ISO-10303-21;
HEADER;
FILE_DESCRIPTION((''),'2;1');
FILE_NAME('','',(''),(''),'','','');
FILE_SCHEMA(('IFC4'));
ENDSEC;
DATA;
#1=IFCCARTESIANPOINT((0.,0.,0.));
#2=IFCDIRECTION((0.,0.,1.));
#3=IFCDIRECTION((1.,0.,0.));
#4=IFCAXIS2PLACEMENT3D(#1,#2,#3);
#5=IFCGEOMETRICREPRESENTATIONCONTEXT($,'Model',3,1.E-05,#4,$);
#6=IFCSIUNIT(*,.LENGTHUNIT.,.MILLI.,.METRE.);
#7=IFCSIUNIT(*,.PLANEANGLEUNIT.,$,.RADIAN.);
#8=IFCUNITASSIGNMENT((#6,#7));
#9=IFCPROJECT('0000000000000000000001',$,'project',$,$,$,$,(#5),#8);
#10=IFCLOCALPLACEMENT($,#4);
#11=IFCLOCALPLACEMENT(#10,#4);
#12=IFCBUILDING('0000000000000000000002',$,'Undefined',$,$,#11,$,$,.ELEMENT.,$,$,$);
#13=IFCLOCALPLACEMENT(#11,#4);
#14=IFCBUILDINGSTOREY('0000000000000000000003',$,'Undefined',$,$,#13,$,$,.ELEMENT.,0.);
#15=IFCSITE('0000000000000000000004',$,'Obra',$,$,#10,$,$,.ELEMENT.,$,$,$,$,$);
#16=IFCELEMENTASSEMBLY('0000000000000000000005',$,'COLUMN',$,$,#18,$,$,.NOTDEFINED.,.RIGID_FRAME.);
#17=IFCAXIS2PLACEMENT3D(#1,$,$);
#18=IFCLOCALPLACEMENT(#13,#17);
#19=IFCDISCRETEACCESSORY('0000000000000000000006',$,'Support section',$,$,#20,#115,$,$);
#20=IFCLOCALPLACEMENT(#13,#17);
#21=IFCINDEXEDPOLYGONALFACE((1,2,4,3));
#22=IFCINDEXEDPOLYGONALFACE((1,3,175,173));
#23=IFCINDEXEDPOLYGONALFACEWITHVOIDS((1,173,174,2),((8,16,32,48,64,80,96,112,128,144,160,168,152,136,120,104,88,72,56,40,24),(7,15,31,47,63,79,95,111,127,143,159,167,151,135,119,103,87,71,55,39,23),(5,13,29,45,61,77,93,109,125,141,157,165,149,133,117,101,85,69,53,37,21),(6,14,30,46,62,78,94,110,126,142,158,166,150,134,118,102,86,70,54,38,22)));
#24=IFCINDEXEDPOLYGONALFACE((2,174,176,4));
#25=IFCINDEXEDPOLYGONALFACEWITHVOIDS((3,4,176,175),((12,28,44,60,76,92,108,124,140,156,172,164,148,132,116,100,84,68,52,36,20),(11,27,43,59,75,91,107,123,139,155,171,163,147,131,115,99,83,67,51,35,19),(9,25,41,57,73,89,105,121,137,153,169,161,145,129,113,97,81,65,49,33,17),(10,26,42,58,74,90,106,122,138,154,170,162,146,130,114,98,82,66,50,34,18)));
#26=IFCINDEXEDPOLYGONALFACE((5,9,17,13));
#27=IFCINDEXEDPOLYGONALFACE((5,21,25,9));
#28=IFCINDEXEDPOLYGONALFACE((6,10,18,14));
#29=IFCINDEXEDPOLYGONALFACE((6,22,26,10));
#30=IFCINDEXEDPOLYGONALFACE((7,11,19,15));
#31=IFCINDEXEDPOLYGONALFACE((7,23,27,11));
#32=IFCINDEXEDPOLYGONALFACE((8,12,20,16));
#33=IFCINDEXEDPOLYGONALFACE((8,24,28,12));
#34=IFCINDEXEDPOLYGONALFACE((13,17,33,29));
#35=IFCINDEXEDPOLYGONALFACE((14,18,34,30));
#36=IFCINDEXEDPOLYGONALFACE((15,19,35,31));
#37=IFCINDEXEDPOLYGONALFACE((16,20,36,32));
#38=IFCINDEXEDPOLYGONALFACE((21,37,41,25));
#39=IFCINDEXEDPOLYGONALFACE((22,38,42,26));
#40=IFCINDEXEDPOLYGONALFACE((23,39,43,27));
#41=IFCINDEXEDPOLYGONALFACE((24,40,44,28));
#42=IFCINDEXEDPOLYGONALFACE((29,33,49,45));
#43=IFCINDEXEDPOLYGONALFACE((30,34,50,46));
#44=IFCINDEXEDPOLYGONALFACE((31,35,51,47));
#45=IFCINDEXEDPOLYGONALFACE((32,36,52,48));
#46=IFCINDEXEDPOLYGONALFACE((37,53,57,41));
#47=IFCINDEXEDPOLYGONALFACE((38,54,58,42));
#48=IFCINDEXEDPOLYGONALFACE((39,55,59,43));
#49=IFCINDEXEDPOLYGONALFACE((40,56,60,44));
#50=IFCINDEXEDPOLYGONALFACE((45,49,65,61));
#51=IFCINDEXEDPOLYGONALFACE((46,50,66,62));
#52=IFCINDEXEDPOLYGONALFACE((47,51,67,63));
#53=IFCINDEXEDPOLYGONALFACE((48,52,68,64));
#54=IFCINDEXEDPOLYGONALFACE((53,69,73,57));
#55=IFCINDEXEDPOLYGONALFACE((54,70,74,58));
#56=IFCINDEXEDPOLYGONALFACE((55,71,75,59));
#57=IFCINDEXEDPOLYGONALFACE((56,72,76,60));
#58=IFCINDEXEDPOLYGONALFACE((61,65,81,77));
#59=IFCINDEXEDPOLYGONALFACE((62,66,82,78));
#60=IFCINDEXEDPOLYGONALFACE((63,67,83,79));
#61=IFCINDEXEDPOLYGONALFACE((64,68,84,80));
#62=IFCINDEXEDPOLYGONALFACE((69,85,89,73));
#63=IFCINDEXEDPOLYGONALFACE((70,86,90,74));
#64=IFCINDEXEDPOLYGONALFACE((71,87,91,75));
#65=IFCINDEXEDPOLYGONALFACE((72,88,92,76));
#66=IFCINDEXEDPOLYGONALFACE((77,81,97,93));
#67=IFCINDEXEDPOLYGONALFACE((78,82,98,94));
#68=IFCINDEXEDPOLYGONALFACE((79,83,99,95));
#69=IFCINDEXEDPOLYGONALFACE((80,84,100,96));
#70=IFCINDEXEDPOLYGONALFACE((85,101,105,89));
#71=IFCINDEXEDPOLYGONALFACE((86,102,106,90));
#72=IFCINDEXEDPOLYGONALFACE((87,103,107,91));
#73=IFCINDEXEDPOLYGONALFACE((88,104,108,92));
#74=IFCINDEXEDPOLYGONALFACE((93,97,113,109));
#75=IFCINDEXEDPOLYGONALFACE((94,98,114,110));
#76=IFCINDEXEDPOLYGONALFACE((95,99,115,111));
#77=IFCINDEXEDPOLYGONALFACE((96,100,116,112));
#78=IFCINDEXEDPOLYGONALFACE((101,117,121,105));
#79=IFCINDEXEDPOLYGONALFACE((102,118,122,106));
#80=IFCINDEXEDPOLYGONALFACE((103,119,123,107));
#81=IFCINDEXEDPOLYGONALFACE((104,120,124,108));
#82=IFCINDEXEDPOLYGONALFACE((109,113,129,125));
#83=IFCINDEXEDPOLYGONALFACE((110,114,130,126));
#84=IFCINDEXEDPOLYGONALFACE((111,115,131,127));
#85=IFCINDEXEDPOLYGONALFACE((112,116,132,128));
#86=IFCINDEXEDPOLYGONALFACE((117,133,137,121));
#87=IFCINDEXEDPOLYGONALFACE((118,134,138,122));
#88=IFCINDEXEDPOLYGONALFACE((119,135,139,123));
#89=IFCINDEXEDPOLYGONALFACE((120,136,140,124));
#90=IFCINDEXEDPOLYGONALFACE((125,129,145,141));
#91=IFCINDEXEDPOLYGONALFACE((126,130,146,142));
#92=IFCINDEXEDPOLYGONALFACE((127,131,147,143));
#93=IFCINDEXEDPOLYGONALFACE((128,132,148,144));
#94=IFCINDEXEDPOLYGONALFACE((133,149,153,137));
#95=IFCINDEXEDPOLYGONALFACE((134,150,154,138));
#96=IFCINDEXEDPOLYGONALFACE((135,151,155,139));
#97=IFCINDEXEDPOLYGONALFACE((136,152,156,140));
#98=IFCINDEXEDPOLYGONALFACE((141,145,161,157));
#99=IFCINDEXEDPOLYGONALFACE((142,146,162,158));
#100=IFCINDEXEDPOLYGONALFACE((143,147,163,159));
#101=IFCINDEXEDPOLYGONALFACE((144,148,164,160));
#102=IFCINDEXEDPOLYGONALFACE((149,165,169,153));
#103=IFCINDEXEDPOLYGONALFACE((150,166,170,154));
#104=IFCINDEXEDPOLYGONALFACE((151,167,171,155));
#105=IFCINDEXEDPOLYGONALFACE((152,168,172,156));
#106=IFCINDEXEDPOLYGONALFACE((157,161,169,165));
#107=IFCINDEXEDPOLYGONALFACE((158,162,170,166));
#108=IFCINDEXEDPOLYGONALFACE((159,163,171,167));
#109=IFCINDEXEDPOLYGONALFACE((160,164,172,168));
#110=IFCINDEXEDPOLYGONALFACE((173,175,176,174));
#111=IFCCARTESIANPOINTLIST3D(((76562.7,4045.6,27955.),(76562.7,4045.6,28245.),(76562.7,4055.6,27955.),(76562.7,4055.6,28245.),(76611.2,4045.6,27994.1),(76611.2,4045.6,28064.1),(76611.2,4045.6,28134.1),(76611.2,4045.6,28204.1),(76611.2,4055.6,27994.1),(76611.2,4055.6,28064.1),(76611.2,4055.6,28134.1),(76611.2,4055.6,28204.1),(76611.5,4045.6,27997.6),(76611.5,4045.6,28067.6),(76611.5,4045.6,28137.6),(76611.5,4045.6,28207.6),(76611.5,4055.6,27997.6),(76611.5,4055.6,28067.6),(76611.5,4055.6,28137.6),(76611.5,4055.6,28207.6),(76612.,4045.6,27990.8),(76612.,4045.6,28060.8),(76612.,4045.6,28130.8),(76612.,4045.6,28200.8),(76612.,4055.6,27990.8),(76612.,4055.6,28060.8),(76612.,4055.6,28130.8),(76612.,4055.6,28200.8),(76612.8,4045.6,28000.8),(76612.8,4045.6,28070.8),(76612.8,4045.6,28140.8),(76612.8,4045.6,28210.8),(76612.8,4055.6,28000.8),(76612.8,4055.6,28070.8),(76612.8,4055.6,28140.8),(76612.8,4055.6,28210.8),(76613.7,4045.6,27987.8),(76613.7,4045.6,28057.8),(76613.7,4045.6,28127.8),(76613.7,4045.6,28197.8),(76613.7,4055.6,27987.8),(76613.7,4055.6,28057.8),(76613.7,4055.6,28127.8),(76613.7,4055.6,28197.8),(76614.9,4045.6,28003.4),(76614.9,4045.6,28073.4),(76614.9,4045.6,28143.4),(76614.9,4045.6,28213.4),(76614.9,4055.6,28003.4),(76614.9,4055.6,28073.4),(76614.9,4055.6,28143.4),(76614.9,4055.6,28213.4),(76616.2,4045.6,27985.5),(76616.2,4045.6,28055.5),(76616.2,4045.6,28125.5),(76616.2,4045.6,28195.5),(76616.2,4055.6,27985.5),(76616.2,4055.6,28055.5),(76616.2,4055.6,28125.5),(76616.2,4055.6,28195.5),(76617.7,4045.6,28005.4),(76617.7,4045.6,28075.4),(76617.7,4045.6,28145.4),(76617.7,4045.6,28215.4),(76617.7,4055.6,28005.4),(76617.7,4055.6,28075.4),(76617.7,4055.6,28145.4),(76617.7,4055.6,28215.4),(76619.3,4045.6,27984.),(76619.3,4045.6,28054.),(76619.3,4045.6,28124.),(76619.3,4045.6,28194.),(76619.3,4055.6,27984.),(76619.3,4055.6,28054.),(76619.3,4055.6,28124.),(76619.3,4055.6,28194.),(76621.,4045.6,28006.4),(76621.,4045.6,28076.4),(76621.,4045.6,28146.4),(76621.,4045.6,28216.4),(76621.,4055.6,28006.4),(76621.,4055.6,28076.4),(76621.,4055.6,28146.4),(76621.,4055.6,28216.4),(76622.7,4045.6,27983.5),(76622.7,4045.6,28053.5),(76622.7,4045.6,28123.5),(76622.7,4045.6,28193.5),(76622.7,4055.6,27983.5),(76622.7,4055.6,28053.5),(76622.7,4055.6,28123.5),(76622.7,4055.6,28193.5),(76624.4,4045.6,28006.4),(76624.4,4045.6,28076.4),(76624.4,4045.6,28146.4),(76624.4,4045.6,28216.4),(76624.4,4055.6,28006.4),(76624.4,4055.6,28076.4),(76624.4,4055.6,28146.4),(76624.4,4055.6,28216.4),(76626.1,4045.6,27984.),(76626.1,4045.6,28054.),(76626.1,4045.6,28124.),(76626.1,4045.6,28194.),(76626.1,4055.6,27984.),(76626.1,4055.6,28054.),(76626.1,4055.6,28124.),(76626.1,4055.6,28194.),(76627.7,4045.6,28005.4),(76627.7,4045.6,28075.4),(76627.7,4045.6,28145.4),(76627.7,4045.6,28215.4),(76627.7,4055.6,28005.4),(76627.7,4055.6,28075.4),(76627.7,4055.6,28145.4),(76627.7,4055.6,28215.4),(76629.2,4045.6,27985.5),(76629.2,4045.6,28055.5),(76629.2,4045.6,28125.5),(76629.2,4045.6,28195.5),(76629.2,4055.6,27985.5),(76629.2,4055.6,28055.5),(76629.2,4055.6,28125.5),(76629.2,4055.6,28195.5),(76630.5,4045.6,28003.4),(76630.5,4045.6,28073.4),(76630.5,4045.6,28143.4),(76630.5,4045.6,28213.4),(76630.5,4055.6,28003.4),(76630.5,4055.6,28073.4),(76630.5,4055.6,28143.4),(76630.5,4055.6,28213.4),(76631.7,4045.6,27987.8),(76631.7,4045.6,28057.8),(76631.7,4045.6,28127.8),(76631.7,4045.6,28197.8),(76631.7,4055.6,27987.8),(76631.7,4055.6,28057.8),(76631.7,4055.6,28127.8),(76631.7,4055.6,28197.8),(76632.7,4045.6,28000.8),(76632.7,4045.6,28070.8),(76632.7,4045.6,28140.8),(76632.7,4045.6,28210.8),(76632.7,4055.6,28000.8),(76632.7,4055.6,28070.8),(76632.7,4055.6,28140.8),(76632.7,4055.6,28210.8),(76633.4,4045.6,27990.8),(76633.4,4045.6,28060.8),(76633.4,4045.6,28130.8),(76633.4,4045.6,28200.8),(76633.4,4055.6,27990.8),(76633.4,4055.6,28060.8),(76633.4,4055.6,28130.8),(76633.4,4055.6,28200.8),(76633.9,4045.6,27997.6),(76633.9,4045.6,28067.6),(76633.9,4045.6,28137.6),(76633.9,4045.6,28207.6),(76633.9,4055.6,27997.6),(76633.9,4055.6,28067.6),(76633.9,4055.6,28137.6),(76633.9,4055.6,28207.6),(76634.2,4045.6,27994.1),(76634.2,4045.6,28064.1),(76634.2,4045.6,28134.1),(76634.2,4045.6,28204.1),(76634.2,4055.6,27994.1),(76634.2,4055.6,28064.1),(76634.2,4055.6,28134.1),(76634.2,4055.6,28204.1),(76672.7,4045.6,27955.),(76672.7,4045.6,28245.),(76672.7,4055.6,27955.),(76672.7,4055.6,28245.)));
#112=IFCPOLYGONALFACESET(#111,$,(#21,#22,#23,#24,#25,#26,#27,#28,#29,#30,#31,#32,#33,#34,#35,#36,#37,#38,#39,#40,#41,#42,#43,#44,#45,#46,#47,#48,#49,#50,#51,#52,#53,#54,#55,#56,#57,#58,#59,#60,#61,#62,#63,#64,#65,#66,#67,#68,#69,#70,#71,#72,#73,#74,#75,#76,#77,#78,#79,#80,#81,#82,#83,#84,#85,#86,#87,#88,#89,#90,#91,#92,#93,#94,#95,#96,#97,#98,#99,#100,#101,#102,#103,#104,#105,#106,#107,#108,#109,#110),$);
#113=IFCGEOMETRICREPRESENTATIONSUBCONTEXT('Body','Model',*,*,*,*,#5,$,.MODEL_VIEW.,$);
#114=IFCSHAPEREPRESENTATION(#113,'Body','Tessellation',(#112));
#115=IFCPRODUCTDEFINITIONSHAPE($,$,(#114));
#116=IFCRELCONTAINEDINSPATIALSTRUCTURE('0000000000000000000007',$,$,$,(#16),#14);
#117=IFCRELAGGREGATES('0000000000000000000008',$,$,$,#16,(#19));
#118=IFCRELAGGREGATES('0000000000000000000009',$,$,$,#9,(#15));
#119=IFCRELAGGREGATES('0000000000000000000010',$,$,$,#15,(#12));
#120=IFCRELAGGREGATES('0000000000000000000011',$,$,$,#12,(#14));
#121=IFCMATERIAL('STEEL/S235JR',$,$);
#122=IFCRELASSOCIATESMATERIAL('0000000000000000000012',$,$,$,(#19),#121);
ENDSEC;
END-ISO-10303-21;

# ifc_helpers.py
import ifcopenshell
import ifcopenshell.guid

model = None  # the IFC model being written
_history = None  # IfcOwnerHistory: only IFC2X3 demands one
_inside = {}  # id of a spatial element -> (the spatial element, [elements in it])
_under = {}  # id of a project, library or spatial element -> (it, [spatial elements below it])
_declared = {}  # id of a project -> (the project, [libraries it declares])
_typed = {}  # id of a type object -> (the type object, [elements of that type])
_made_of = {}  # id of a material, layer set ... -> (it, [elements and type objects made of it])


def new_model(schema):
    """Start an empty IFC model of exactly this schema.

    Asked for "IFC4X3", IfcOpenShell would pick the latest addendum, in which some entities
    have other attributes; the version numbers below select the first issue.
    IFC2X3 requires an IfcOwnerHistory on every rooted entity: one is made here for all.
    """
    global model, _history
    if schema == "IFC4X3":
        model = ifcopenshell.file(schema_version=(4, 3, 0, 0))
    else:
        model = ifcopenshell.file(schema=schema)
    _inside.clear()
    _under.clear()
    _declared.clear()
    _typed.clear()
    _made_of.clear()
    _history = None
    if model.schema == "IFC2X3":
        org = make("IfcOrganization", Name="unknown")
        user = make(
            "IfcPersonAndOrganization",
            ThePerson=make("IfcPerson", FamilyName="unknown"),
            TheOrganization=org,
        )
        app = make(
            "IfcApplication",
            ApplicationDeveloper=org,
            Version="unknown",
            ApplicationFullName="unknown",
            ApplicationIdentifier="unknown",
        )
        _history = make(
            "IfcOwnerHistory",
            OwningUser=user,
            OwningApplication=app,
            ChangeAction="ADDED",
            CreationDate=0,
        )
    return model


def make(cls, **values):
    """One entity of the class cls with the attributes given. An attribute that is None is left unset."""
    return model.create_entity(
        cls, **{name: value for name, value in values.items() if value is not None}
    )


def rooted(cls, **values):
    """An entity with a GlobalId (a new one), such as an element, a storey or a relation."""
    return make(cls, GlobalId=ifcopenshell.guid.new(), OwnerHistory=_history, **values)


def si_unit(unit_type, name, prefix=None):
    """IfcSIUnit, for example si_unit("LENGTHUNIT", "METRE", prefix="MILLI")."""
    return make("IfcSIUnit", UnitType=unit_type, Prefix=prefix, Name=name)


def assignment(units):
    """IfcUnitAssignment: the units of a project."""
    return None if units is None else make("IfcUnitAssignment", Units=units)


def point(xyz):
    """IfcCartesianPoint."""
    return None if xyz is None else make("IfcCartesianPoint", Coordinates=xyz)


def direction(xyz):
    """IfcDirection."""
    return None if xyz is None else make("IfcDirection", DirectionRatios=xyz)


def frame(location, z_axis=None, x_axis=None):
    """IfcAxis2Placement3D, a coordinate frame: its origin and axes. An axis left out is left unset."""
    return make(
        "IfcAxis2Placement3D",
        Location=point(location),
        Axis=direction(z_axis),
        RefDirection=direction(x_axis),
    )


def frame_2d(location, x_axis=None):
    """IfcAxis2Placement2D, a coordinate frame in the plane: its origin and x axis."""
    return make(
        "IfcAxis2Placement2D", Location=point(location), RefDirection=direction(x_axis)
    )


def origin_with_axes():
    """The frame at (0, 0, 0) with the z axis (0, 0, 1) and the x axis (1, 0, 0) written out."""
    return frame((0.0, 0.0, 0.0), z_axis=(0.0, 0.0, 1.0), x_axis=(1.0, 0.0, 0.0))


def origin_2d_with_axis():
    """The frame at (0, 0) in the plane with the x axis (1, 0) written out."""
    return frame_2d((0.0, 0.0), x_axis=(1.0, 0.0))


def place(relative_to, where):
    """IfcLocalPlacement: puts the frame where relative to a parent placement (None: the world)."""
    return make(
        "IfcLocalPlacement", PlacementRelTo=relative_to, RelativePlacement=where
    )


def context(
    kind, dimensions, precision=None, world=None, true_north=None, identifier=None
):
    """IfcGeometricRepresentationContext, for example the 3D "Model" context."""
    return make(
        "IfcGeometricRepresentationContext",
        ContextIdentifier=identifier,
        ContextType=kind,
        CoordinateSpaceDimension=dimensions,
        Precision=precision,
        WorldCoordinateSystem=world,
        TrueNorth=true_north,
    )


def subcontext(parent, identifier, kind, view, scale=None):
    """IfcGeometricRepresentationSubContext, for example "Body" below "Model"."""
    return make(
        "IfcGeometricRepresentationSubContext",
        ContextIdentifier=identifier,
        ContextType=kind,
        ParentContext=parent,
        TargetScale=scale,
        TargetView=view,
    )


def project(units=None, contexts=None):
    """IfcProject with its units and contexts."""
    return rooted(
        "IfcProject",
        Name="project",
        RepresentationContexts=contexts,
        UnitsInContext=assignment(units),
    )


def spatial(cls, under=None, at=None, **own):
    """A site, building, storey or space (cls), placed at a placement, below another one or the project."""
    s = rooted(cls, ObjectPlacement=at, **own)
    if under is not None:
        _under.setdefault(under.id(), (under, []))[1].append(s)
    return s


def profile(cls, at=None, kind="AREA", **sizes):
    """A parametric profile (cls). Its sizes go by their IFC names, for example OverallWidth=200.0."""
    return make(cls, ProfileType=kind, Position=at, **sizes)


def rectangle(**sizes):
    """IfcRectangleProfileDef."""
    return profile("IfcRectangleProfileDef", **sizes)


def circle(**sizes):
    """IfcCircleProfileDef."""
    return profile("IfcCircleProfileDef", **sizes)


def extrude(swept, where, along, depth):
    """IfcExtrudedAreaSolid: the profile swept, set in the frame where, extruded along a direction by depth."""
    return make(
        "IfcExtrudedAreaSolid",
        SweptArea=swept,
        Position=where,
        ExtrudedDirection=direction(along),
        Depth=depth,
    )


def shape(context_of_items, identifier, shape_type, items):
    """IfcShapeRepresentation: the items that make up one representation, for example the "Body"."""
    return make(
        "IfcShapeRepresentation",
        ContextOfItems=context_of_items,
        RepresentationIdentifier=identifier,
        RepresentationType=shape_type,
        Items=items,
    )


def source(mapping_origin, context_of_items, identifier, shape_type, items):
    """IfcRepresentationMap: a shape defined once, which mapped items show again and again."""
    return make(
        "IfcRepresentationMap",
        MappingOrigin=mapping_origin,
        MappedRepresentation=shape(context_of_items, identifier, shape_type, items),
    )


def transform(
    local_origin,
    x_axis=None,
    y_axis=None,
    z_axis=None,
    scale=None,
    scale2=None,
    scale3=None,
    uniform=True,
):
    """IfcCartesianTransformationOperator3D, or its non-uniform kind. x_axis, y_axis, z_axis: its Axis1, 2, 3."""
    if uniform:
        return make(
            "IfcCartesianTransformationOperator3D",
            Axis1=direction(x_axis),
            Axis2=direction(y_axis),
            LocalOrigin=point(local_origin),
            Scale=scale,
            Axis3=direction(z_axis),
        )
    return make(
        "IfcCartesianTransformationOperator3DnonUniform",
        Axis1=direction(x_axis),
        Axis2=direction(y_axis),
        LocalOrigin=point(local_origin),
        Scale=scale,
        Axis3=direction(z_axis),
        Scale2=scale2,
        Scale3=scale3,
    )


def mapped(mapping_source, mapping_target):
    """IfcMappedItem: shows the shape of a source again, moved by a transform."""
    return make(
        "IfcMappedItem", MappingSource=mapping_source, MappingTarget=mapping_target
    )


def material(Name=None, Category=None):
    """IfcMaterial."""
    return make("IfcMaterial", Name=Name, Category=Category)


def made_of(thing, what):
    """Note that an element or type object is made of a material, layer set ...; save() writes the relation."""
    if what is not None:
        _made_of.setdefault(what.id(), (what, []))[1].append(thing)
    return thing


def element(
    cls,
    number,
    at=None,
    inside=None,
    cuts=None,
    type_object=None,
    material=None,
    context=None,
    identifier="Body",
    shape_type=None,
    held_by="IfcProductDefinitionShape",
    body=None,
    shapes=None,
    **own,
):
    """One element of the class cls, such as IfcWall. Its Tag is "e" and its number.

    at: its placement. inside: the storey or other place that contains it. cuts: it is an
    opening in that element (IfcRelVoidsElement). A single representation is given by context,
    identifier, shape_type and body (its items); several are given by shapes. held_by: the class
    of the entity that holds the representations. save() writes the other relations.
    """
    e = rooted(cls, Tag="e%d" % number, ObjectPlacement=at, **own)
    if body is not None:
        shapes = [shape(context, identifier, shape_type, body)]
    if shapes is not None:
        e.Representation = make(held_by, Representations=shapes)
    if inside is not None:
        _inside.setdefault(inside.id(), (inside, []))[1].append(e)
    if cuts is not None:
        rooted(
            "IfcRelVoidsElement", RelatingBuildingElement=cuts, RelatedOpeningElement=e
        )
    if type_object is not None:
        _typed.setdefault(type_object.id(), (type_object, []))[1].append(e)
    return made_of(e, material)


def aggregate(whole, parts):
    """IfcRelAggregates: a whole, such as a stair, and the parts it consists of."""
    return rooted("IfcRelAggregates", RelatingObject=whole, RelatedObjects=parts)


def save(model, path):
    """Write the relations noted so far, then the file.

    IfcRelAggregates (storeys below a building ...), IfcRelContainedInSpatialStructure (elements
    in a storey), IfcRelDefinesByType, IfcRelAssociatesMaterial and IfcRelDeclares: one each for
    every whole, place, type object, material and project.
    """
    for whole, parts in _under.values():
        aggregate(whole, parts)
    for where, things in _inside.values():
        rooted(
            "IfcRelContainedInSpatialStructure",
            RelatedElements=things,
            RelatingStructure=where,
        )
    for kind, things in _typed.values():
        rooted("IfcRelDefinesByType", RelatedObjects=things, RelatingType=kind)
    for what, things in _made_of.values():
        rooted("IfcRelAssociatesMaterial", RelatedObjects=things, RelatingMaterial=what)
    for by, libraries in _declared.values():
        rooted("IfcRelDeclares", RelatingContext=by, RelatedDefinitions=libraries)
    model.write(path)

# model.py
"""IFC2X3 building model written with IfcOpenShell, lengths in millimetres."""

from ifc_helpers import new_model, si_unit, frame, origin_with_axes, origin_2d_with_axis, place, context, subcontext, project, spatial, rectangle, circle, extrude, source, transform, mapped, material, element, aggregate, save


model = new_model("IFC2X3")

# Units and contexts
model_context = context("Model", 3, precision=1e-05, world=origin_with_axes())
body_context = subcontext(model_context, "Body", "Model", "MODEL_VIEW")
ifc_project = project(units=[si_unit("LENGTHUNIT", "METRE", prefix="MILLI"), si_unit("PLANEANGLEUNIT", "RADIAN")], contexts=[model_context])

# Site, building, storey
site_placement = place(None, origin_with_axes())
site = spatial("IfcSite", under=ifc_project, at=site_placement, Name="Obra", CompositionType="ELEMENT")
building_placement = place(site_placement, origin_with_axes())
building = spatial("IfcBuilding", under=site, at=building_placement, Name="Undefined", CompositionType="ELEMENT")
storey_placement = place(building_placement, origin_with_axes())
storey = spatial("IfcBuildingStorey", under=building, at=storey_placement, Name="Undefined", CompositionType="ELEMENT", Elevation=0.0)

# Shared definitions
ifc_material_1 = material(Name="STEEL/S235JR")

# Element assembly
assembly_1_placement = place(storey_placement, origin_with_axes())
assembly_1 = element("IfcElementAssembly", 1, at=assembly_1_placement, inside=storey, Name="COLUMN", AssemblyPlace="NOTDEFINED", PredefinedType="RIGID_FRAME")
shared_shape_1 = source(origin_with_axes(), body_context, "Body", "SweptSolid", [
    extrude(circle(Radius=11.5, at=origin_2d_with_axis()), frame((0.0, -14.4, 0.0), z_axis=(0.0, 1.0, 0.0), x_axis=(1.0, 0.0, 0.0)), (0.0, 0.0, 1.0), 10.2),
])

# Discrete accessory, opening
discrete_accessory_1_placement = place(assembly_1_placement, frame((76617.7, 4050.6, 27955.0), z_axis=(0.0, 0.0, 1.0), x_axis=(-1.0, 0.0, 0.0)))
discrete_accessory_1 = element("IfcDiscreteAccessory", 2, at=discrete_accessory_1_placement, material=ifc_material_1, Name="Support section", context=body_context, shape_type="SweptSolid", body=[
    extrude(rectangle(XDim=10.0, YDim=110.0, at=origin_2d_with_axis()), frame((0.0, 0.0, 290.0), z_axis=(0.0, 0.0, -1.0), x_axis=(0.0, 1.0, 0.0)), (0.0, 0.0, 1.0), 290.0),
])
opening_1_placement = place(assembly_1_placement, frame((76572.7, 4059.9, 28300.0), z_axis=(1.0, 0.0, 0.0), x_axis=(0.0, 0.0, -1.0)))
element("IfcOpeningElement", 3, at=opening_1_placement, cuts=discrete_accessory_1, ObjectType="Opening", context=body_context, shape_type="MappedRepresentation", body=[
    mapped(shared_shape_1, transform((95.0, 0.0, 50.0))),
    mapped(shared_shape_1, transform((165.0, 0.0, 50.0))),
    mapped(shared_shape_1, transform((235.0, 0.0, 50.0))),
    mapped(shared_shape_1, transform((305.0, 0.0, 50.0))),
])
aggregate(assembly_1, [discrete_accessory_1])

save(model, "model.ifc")
